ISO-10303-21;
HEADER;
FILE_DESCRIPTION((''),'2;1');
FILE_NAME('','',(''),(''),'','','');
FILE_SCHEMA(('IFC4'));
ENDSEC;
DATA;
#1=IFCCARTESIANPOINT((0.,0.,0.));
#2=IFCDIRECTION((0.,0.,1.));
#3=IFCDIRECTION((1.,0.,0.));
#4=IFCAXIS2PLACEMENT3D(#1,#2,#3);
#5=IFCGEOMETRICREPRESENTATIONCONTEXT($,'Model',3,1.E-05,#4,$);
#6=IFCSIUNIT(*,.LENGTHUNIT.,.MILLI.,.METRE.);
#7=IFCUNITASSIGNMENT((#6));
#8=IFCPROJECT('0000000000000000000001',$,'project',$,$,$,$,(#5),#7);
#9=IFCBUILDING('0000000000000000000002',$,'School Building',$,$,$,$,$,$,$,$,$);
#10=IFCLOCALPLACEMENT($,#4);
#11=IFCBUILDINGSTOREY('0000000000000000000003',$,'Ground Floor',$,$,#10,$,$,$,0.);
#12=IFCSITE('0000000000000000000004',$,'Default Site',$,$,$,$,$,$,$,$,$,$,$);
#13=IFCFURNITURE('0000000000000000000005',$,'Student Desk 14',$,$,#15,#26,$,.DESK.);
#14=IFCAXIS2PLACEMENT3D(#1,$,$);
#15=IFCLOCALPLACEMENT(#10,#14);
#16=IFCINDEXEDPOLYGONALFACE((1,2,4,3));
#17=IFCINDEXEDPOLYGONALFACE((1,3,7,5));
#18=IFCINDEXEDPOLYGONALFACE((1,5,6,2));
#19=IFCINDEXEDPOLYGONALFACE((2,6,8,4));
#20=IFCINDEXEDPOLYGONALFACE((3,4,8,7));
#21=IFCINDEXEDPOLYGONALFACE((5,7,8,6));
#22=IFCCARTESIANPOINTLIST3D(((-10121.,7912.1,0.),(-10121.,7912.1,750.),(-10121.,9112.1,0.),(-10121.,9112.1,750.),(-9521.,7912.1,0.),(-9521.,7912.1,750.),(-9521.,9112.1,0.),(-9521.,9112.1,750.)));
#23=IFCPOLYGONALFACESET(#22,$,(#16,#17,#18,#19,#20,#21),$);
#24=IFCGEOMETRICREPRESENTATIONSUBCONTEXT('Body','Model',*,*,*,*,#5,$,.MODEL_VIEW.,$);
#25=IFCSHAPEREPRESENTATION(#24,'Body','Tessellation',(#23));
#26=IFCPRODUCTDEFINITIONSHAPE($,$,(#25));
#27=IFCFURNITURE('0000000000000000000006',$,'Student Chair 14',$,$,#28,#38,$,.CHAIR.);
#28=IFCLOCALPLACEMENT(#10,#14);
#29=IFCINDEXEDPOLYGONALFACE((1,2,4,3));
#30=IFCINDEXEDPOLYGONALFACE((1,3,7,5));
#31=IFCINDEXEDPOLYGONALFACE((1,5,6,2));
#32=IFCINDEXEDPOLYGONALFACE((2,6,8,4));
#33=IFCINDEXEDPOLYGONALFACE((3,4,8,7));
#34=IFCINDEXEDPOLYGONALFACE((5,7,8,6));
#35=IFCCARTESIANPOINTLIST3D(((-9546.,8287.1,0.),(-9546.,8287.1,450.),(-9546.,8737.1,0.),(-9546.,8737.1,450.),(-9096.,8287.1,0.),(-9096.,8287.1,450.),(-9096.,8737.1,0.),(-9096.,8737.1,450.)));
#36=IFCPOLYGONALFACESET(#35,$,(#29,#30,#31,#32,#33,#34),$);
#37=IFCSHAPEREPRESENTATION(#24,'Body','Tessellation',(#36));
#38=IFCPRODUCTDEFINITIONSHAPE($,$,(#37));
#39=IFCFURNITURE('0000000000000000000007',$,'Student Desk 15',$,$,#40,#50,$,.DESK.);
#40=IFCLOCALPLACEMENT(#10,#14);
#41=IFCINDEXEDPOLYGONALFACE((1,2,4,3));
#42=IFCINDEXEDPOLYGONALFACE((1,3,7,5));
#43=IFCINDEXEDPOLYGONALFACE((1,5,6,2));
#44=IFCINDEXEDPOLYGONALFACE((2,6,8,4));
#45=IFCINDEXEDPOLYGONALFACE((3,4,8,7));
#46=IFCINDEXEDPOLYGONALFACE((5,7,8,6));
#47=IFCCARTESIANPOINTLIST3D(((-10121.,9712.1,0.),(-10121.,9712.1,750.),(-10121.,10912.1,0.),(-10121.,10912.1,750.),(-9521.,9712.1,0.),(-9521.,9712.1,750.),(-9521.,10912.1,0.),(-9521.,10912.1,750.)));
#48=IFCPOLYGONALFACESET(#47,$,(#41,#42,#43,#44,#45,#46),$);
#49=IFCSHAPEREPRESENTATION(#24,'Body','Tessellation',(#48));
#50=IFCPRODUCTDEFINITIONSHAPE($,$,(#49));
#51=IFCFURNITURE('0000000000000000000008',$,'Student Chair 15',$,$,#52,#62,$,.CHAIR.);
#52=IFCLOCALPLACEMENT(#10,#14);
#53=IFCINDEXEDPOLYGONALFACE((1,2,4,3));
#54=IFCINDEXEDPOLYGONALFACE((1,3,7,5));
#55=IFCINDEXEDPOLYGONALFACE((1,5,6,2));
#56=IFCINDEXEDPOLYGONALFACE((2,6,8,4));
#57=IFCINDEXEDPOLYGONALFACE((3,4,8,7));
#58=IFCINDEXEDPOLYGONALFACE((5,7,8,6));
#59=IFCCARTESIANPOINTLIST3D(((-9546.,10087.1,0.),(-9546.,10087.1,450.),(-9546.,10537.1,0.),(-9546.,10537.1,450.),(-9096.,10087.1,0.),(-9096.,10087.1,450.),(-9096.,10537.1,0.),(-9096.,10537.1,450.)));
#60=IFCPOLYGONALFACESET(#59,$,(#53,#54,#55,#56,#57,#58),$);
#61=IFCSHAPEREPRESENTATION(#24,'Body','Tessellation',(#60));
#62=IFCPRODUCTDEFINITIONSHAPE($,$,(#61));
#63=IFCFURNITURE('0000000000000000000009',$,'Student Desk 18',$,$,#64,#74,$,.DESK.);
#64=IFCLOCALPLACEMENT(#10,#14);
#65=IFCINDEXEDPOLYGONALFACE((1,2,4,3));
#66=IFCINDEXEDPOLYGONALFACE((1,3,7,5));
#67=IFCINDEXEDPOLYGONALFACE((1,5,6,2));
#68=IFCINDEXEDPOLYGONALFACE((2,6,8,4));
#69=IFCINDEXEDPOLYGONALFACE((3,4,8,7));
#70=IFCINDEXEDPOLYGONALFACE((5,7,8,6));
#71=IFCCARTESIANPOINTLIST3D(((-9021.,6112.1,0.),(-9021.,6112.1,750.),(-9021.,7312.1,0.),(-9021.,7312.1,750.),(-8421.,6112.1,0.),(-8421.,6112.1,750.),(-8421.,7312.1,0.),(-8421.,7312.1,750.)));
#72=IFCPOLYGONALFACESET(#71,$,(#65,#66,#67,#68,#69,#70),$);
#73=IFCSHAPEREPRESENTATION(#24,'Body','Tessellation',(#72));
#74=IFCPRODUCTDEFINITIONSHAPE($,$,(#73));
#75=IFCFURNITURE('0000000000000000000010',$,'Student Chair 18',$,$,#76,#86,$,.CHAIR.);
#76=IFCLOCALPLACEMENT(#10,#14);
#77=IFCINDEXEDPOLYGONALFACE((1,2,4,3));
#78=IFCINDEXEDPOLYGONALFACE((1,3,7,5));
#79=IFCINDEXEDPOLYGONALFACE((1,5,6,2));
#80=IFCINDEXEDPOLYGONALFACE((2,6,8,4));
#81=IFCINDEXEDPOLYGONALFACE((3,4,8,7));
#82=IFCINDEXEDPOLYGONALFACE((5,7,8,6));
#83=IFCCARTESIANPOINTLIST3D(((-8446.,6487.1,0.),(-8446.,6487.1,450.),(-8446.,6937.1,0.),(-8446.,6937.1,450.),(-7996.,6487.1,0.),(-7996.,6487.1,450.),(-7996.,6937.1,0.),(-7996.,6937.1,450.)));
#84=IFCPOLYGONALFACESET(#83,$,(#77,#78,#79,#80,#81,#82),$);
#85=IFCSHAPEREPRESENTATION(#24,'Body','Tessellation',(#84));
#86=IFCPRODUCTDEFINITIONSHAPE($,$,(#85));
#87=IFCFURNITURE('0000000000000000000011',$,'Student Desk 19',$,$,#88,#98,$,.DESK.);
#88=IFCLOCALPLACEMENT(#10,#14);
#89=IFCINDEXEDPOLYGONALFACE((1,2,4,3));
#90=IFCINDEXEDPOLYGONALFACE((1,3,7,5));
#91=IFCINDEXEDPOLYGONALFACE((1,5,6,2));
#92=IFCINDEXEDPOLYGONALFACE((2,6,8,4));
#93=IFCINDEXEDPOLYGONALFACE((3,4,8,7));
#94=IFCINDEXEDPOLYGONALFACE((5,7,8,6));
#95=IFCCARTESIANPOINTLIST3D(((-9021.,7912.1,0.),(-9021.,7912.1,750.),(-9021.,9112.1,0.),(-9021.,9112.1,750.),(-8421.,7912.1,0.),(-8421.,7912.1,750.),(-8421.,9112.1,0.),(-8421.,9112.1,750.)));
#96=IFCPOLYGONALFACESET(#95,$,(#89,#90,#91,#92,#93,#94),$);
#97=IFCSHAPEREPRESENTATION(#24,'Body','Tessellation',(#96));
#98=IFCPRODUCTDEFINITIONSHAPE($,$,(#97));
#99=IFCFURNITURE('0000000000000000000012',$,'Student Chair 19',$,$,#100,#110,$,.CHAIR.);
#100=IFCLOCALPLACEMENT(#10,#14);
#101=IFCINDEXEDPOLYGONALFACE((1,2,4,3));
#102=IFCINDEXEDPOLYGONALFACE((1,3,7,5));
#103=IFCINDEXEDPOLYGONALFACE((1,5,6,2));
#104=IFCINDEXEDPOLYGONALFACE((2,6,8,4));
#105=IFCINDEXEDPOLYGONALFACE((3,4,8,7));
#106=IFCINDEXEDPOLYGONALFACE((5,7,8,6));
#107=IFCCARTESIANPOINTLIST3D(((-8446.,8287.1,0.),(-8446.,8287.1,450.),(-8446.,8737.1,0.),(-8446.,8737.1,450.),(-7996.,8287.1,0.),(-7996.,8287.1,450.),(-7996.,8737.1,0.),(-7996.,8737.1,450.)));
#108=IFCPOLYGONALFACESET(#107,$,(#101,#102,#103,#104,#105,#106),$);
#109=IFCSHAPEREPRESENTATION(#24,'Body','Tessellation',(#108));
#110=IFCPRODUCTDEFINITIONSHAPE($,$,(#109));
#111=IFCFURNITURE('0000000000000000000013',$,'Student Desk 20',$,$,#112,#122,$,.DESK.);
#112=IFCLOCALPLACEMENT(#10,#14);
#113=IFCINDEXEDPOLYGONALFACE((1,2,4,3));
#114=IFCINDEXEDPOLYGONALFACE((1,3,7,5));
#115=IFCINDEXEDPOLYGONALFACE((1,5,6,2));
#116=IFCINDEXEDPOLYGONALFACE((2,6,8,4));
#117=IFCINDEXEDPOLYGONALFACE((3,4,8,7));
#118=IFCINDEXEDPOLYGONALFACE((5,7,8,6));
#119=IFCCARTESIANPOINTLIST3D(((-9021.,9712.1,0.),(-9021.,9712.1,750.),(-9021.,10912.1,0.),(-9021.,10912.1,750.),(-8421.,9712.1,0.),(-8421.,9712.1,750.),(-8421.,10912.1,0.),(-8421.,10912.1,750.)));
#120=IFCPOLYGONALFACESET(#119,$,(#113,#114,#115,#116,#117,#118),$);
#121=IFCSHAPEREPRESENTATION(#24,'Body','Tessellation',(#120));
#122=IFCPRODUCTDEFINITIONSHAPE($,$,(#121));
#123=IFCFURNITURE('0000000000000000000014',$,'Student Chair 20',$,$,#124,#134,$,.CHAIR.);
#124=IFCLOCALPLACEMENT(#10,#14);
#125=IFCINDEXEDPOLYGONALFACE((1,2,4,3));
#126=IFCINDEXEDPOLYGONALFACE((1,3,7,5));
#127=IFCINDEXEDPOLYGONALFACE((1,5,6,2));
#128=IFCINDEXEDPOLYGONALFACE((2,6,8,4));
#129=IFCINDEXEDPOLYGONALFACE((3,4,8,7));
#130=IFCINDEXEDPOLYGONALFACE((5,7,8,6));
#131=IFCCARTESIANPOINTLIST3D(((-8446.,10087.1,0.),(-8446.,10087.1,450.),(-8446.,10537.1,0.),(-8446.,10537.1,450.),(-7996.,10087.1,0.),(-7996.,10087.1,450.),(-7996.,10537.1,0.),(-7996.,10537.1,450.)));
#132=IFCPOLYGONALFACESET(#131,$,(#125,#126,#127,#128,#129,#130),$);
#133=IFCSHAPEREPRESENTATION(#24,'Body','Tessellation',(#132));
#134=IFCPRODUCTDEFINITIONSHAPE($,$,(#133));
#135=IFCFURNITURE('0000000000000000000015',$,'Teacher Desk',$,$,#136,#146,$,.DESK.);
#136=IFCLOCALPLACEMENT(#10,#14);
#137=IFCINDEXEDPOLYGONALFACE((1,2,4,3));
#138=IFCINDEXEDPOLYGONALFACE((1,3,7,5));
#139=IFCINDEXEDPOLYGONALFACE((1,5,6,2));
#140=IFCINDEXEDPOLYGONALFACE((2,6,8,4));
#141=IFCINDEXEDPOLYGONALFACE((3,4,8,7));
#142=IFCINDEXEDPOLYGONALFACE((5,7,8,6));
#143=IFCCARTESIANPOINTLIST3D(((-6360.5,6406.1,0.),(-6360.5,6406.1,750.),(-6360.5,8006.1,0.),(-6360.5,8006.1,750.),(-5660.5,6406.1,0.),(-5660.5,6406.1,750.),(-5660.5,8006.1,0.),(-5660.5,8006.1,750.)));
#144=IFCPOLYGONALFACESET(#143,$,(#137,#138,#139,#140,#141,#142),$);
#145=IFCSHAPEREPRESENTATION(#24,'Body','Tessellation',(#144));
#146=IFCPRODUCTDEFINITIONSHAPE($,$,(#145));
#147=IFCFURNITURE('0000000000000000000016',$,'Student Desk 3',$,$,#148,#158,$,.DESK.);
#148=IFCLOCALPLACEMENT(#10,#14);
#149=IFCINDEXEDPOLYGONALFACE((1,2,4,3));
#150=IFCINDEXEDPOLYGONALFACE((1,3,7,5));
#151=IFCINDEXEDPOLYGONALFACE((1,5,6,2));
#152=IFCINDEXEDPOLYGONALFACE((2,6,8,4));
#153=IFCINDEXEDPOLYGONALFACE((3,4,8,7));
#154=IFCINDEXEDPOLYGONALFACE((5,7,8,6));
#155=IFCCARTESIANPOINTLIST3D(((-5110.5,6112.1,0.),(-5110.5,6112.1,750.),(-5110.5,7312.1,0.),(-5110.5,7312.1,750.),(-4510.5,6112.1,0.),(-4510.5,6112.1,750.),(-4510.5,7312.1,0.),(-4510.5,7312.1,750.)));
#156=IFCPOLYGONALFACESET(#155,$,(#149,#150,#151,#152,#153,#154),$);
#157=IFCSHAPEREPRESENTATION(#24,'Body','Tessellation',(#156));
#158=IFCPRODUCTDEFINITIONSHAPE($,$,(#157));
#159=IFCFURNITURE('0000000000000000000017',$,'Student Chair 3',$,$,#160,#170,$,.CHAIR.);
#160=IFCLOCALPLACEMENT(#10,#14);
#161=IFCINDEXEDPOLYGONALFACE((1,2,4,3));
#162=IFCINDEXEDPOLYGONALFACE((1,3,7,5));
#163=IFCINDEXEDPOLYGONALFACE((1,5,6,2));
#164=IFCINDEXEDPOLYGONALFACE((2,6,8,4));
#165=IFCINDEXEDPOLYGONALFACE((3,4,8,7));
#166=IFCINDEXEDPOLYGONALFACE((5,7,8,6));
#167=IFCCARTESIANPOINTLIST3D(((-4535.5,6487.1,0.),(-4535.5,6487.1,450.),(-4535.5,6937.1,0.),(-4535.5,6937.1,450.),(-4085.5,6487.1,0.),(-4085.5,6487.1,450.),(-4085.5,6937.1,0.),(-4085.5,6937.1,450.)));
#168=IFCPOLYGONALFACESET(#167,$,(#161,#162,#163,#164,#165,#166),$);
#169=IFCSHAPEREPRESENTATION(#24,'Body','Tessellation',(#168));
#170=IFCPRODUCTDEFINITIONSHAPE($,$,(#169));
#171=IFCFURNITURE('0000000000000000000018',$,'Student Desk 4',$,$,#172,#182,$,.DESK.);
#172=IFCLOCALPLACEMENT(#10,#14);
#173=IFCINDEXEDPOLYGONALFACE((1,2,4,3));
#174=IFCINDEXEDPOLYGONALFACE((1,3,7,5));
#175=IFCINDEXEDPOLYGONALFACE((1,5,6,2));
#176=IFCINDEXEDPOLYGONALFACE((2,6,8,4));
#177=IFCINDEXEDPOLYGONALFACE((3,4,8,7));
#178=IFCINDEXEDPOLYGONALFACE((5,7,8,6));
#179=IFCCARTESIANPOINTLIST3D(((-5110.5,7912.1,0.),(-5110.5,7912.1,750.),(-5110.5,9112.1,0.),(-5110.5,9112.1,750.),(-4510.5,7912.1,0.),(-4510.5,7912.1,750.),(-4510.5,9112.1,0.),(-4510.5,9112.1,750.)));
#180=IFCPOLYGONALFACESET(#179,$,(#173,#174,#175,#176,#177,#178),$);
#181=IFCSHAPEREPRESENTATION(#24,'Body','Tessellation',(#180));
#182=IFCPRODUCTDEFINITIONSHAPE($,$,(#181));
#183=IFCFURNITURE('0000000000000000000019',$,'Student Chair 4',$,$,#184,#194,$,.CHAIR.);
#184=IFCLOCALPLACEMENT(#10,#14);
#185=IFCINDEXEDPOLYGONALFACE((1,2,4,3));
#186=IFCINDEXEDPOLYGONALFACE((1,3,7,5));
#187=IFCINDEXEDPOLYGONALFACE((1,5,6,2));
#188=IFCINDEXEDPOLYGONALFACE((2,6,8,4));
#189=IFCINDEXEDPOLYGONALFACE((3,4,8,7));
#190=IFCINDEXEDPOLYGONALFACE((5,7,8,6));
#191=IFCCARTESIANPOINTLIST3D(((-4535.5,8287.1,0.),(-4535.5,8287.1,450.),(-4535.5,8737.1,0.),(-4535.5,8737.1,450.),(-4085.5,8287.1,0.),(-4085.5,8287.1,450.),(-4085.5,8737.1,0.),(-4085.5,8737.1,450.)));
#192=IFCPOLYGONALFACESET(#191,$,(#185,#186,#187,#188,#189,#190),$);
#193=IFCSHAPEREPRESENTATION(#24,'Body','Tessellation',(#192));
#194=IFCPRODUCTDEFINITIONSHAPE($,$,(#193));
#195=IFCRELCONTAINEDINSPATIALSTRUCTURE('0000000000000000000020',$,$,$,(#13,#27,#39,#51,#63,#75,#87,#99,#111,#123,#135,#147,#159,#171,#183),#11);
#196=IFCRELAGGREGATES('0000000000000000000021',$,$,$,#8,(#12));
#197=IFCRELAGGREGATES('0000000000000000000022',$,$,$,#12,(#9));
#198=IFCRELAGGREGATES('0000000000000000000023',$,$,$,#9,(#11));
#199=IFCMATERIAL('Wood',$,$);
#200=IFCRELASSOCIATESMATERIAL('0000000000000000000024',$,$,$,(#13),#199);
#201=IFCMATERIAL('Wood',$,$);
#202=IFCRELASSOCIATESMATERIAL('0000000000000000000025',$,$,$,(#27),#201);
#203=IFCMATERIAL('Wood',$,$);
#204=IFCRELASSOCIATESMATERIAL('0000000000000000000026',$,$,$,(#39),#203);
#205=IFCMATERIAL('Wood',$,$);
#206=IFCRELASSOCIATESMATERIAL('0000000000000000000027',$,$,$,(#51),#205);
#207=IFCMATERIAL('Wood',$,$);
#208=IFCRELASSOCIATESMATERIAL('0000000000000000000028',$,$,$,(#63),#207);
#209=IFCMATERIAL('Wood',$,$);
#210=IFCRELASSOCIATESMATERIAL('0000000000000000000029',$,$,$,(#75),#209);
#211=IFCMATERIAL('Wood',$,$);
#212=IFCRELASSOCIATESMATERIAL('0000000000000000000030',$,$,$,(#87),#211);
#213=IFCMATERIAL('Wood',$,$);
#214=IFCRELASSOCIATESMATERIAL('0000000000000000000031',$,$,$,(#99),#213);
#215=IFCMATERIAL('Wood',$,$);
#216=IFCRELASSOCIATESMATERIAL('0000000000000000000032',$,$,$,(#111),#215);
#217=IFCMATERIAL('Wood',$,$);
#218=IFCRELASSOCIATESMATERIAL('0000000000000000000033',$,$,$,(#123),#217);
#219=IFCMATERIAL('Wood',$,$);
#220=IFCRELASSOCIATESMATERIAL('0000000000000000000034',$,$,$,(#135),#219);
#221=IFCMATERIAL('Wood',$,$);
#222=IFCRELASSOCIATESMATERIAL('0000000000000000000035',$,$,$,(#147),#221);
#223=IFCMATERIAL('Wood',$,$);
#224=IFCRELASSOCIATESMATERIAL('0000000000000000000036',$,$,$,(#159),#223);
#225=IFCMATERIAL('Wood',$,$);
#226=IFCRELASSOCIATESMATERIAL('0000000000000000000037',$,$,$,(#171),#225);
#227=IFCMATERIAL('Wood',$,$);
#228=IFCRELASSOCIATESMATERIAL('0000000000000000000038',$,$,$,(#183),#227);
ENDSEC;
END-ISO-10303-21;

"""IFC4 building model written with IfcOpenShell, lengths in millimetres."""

from ifc_helpers import new_model, si_unit, frame, origin_with_axes, origin_2d, place, context, subcontext, project, spatial, rectangle, extrude, material, element, save


model = new_model("IFC4")

# Units and contexts
model_context = context("Model", 3, precision=1e-05, world=origin_with_axes())
body_context = subcontext(model_context, "Body", "Model", "MODEL_VIEW")
ifc_project = project(units=[si_unit("LENGTHUNIT", "METRE", prefix="MILLI")], contexts=[model_context])

# Site, building, storey
site = spatial("IfcSite", under=ifc_project, Name="Default Site")
building = spatial("IfcBuilding", under=site, Name="School Building")
storey_placement = place(None, origin_with_axes())
storey = spatial("IfcBuildingStorey", under=building, at=storey_placement, Name="Ground Floor", Elevation=0.0)

# Furniture
ifc_material_1 = material(Name="Wood")
furniture_1_placement = place(storey_placement, frame((-9821.0, 8512.1, 0.0), z_axis=(0.0, 0.0, 1.0), x_axis=(0.0, 1.0, 0.0)))
element("IfcFurniture", 1, at=furniture_1_placement, inside=storey, material=ifc_material_1, Name="Student Desk 14", PredefinedType="DESK", context=body_context, shape_type="SweptSolid", body=[
    extrude(rectangle(XDim=1200.0, YDim=600.0, at=origin_2d()), origin_with_axes(), (0.0, 0.0, 1.0), 750.0),
])
ifc_material_2 = material(Name="Wood")
furniture_2_placement = place(storey_placement, frame((-9321.0, 8512.1, 0.0), z_axis=(0.0, 0.0, 1.0), x_axis=(1.0, 0.0, 0.0)))
element("IfcFurniture", 2, at=furniture_2_placement, inside=storey, material=ifc_material_2, Name="Student Chair 14", PredefinedType="CHAIR", context=body_context, shape_type="SweptSolid", body=[
    extrude(rectangle(XDim=450.0, YDim=450.0, at=origin_2d()), origin_with_axes(), (0.0, 0.0, 1.0), 450.0),
])
ifc_material_3 = material(Name="Wood")
furniture_3_placement = place(storey_placement, frame((-9821.0, 10312.1, 0.0), z_axis=(0.0, 0.0, 1.0), x_axis=(0.0, 1.0, 0.0)))
element("IfcFurniture", 3, at=furniture_3_placement, inside=storey, material=ifc_material_3, Name="Student Desk 15", PredefinedType="DESK", context=body_context, shape_type="SweptSolid", body=[
    extrude(rectangle(XDim=1200.0, YDim=600.0, at=origin_2d()), origin_with_axes(), (0.0, 0.0, 1.0), 750.0),
])
ifc_material_4 = material(Name="Wood")
furniture_4_placement = place(storey_placement, frame((-9321.0, 10312.1, 0.0), z_axis=(0.0, 0.0, 1.0), x_axis=(1.0, 0.0, 0.0)))
element("IfcFurniture", 4, at=furniture_4_placement, inside=storey, material=ifc_material_4, Name="Student Chair 15", PredefinedType="CHAIR", context=body_context, shape_type="SweptSolid", body=[
    extrude(rectangle(XDim=450.0, YDim=450.0, at=origin_2d()), origin_with_axes(), (0.0, 0.0, 1.0), 450.0),
])
ifc_material_5 = material(Name="Wood")
furniture_5_placement = place(storey_placement, frame((-8721.0, 6712.1, 0.0), z_axis=(0.0, 0.0, 1.0), x_axis=(0.0, 1.0, 0.0)))
element("IfcFurniture", 5, at=furniture_5_placement, inside=storey, material=ifc_material_5, Name="Student Desk 18", PredefinedType="DESK", context=body_context, shape_type="SweptSolid", body=[
    extrude(rectangle(XDim=1200.0, YDim=600.0, at=origin_2d()), origin_with_axes(), (0.0, 0.0, 1.0), 750.0),
])
ifc_material_6 = material(Name="Wood")
furniture_6_placement = place(storey_placement, frame((-8221.0, 6712.1, 0.0), z_axis=(0.0, 0.0, 1.0), x_axis=(1.0, 0.0, 0.0)))
element("IfcFurniture", 6, at=furniture_6_placement, inside=storey, material=ifc_material_6, Name="Student Chair 18", PredefinedType="CHAIR", context=body_context, shape_type="SweptSolid", body=[
    extrude(rectangle(XDim=450.0, YDim=450.0, at=origin_2d()), origin_with_axes(), (0.0, 0.0, 1.0), 450.0),
])
ifc_material_7 = material(Name="Wood")
furniture_7_placement = place(storey_placement, frame((-8721.0, 8512.1, 0.0), z_axis=(0.0, 0.0, 1.0), x_axis=(0.0, 1.0, 0.0)))
element("IfcFurniture", 7, at=furniture_7_placement, inside=storey, material=ifc_material_7, Name="Student Desk 19", PredefinedType="DESK", context=body_context, shape_type="SweptSolid", body=[
    extrude(rectangle(XDim=1200.0, YDim=600.0, at=origin_2d()), origin_with_axes(), (0.0, 0.0, 1.0), 750.0),
])
ifc_material_8 = material(Name="Wood")
furniture_8_placement = place(storey_placement, frame((-8221.0, 8512.1, 0.0), z_axis=(0.0, 0.0, 1.0), x_axis=(1.0, 0.0, 0.0)))
element("IfcFurniture", 8, at=furniture_8_placement, inside=storey, material=ifc_material_8, Name="Student Chair 19", PredefinedType="CHAIR", context=body_context, shape_type="SweptSolid", body=[
    extrude(rectangle(XDim=450.0, YDim=450.0, at=origin_2d()), origin_with_axes(), (0.0, 0.0, 1.0), 450.0),
])
ifc_material_9 = material(Name="Wood")
furniture_9_placement = place(storey_placement, frame((-8721.0, 10312.1, 0.0), z_axis=(0.0, 0.0, 1.0), x_axis=(0.0, 1.0, 0.0)))
element("IfcFurniture", 9, at=furniture_9_placement, inside=storey, material=ifc_material_9, Name="Student Desk 20", PredefinedType="DESK", context=body_context, shape_type="SweptSolid", body=[
    extrude(rectangle(XDim=1200.0, YDim=600.0, at=origin_2d()), origin_with_axes(), (0.0, 0.0, 1.0), 750.0),
])
ifc_material_10 = material(Name="Wood")
furniture_10_placement = place(storey_placement, frame((-8221.0, 10312.1, 0.0), z_axis=(0.0, 0.0, 1.0), x_axis=(1.0, 0.0, 0.0)))
element("IfcFurniture", 10, at=furniture_10_placement, inside=storey, material=ifc_material_10, Name="Student Chair 20", PredefinedType="CHAIR", context=body_context, shape_type="SweptSolid", body=[
    extrude(rectangle(XDim=450.0, YDim=450.0, at=origin_2d()), origin_with_axes(), (0.0, 0.0, 1.0), 450.0),
])
ifc_material_11 = material(Name="Wood")
furniture_11_placement = place(storey_placement, frame((-6010.5, 7206.1, 0.0), z_axis=(0.0, 0.0, 1.0), x_axis=(0.0, 1.0, 0.0)))
element("IfcFurniture", 11, at=furniture_11_placement, inside=storey, material=ifc_material_11, Name="Teacher Desk", PredefinedType="DESK", context=body_context, shape_type="SweptSolid", body=[
    extrude(rectangle(XDim=1600.0, YDim=700.0, at=origin_2d()), origin_with_axes(), (0.0, 0.0, 1.0), 750.0),
])
ifc_material_12 = material(Name="Wood")
furniture_12_placement = place(storey_placement, frame((-4810.5, 6712.1, 0.0), z_axis=(0.0, 0.0, 1.0), x_axis=(0.0, 1.0, 0.0)))
element("IfcFurniture", 12, at=furniture_12_placement, inside=storey, material=ifc_material_12, Name="Student Desk 3", PredefinedType="DESK", context=body_context, shape_type="SweptSolid", body=[
    extrude(rectangle(XDim=1200.0, YDim=600.0, at=origin_2d()), origin_with_axes(), (0.0, 0.0, 1.0), 750.0),
])
ifc_material_13 = material(Name="Wood")
furniture_13_placement = place(storey_placement, frame((-4310.5, 6712.1, 0.0), z_axis=(0.0, 0.0, 1.0), x_axis=(1.0, 0.0, 0.0)))
element("IfcFurniture", 13, at=furniture_13_placement, inside=storey, material=ifc_material_13, Name="Student Chair 3", PredefinedType="CHAIR", context=body_context, shape_type="SweptSolid", body=[
    extrude(rectangle(XDim=450.0, YDim=450.0, at=origin_2d()), origin_with_axes(), (0.0, 0.0, 1.0), 450.0),
])
ifc_material_14 = material(Name="Wood")
furniture_14_placement = place(storey_placement, frame((-4810.5, 8512.1, 0.0), z_axis=(0.0, 0.0, 1.0), x_axis=(0.0, 1.0, 0.0)))
element("IfcFurniture", 14, at=furniture_14_placement, inside=storey, material=ifc_material_14, Name="Student Desk 4", PredefinedType="DESK", context=body_context, shape_type="SweptSolid", body=[
    extrude(rectangle(XDim=1200.0, YDim=600.0, at=origin_2d()), origin_with_axes(), (0.0, 0.0, 1.0), 750.0),
])
ifc_material_15 = material(Name="Wood")
furniture_15_placement = place(storey_placement, frame((-4310.5, 8512.1, 0.0), z_axis=(0.0, 0.0, 1.0), x_axis=(1.0, 0.0, 0.0)))
element("IfcFurniture", 15, at=furniture_15_placement, inside=storey, material=ifc_material_15, Name="Student Chair 4", PredefinedType="CHAIR", context=body_context, shape_type="SweptSolid", body=[
    extrude(rectangle(XDim=450.0, YDim=450.0, at=origin_2d()), origin_with_axes(), (0.0, 0.0, 1.0), 450.0),
])

save(model, "model.ifc")
